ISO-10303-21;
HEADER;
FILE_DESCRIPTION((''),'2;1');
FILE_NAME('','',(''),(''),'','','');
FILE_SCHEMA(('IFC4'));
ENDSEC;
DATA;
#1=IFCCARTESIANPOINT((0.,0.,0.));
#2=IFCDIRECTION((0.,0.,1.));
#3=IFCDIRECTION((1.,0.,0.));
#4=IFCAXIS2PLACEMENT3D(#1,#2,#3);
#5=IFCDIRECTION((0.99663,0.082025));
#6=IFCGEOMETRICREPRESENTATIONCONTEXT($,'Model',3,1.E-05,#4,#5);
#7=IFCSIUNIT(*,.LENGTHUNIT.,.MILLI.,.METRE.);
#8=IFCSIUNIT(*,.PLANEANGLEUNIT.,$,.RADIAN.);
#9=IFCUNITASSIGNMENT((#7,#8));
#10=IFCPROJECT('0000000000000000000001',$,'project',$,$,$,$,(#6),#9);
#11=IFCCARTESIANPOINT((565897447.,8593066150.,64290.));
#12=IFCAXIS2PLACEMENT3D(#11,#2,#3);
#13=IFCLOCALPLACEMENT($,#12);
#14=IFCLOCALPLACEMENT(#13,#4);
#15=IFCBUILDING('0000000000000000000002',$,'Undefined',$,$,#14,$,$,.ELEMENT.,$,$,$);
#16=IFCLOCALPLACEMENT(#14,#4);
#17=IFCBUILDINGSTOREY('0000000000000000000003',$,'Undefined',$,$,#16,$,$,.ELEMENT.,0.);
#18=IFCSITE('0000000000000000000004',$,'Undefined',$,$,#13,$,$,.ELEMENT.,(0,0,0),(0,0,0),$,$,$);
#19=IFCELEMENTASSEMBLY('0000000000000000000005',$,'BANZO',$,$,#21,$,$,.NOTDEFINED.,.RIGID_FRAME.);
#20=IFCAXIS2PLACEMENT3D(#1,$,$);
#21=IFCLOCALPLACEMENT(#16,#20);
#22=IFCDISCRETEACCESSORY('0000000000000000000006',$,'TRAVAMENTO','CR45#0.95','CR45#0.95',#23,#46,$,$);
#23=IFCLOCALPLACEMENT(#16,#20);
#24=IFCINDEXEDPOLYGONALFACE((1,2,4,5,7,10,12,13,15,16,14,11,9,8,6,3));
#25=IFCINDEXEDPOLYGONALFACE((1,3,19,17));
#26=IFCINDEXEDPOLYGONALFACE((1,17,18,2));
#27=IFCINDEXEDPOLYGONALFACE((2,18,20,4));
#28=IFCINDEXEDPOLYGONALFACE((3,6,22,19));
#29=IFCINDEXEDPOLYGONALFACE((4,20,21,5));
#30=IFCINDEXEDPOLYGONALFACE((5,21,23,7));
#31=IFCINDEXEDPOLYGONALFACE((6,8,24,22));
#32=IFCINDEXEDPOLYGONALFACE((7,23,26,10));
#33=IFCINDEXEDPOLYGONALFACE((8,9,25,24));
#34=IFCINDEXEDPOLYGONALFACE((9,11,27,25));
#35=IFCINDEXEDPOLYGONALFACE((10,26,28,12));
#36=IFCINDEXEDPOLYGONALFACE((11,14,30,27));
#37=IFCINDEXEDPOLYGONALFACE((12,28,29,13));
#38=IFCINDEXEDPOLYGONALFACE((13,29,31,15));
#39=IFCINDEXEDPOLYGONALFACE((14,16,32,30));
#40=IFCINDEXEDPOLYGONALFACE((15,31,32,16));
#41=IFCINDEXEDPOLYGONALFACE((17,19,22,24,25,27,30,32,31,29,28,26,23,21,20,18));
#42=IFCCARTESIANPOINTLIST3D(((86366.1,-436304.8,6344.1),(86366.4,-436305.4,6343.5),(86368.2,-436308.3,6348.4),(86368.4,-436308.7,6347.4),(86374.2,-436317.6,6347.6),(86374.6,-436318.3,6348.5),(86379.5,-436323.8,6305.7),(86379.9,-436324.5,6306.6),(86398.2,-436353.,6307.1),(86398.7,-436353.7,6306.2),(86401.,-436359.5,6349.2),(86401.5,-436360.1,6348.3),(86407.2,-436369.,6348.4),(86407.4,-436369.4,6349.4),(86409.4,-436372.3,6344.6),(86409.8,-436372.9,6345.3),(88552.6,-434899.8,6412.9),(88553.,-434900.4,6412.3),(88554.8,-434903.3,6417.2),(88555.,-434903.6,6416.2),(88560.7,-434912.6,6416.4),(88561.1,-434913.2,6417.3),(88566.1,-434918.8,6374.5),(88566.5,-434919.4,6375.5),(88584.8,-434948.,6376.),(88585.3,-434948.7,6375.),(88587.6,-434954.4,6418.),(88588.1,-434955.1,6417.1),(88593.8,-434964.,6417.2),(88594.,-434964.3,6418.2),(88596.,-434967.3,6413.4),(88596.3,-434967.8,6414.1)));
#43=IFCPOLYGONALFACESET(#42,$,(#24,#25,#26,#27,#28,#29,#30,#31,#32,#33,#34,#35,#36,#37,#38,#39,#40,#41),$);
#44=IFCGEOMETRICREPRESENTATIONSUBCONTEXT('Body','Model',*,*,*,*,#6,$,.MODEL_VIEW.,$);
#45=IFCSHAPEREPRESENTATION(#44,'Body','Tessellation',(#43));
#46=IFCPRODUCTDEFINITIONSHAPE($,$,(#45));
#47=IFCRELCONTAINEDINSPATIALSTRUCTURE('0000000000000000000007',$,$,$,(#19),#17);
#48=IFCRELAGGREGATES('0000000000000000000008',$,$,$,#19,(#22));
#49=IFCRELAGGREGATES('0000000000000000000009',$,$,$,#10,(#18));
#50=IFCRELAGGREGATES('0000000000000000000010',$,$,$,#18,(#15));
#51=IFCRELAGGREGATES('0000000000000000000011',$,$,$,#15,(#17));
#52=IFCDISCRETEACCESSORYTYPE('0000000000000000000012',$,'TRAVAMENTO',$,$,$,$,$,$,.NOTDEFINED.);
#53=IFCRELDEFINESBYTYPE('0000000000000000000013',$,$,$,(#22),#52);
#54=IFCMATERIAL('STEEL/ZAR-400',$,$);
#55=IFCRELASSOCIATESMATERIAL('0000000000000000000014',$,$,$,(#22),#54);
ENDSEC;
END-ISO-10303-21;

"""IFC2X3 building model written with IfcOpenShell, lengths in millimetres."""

from ifc_helpers import new_model, si_unit, direction, frame, origin_with_axes, place, context, subcontext, project, spatial, polyline, outline, extrude, material, type_object, element, aggregate, save


model = new_model("IFC2X3")

# Units and contexts
model_context = context("Model", 3, precision=1e-05, world=origin_with_axes(), true_north=direction((0.99663, 0.082025)))
body_context = subcontext(model_context, "Body", "Model", "MODEL_VIEW")
ifc_project = project(units=[si_unit("LENGTHUNIT", "METRE", prefix="MILLI"), si_unit("PLANEANGLEUNIT", "RADIAN")], contexts=[model_context])

# Site, building, storey
site_placement = place(None, frame((565897447.0, 8593066150.0, 64290.0), z_axis=(0.0, 0.0, 1.0), x_axis=(1.0, 0.0, 0.0)))
site = spatial("IfcSite", under=ifc_project, at=site_placement, Name="Undefined", CompositionType="ELEMENT", RefLatitude=(0, 0, 0), RefLongitude=(0, 0, 0))
building_placement = place(site_placement, origin_with_axes())
building = spatial("IfcBuilding", under=site, at=building_placement, Name="Undefined", CompositionType="ELEMENT")
storey_placement = place(building_placement, origin_with_axes())
storey = spatial("IfcBuildingStorey", under=building, at=storey_placement, Name="Undefined", CompositionType="ELEMENT", Elevation=0.0)

# Element assembly
ifc_material_1 = material(Name="STEEL/ZAR-400")
assembly_1_placement = place(storey_placement, origin_with_axes())
assembly_1 = element("IfcElementAssembly", 1, at=assembly_1_placement, inside=storey, Name="BANZO", AssemblyPlace="NOTDEFINED", PredefinedType="RIGID_FRAME")

# Shared definitions
discrete_accessory_type_1 = type_object("IfcDiscreteAccessoryType", Name="TRAVAMENTO")

# Discrete accessory
discrete_accessory_1_placement = place(assembly_1_placement, frame((88574.8, -434933.5, 6396.2), z_axis=(0.029884, 0.002459, -0.99955), x_axis=(-0.840995, -0.540395, -0.026473)))
discrete_accessory_1 = element("IfcDiscreteAccessory", 2, at=discrete_accessory_1_placement, type_object=discrete_accessory_type_1, material=ifc_material_1, Name="TRAVAMENTO", Description="CR45#0.95", ObjectType="CR45#0.95", context=body_context, shape_type="SweptSolid", body=[
    extrude(outline(polyline([(-35.5, -20.5), (-24.9, -20.5), (-17.4, 21.5), (18.1, 21.5), (25.6, -20.5), (36.2, -20.5), (40.1, -16.6), (40.8, -17.3), (36.6, -21.5), (24.8, -21.5), (17.3, 20.5), (-16.6, 20.5), (-24.1, -21.5), (-35.9, -21.5), (-40.1, -17.3), (-39.4, -16.6), (-35.5, -20.5)])), frame((2600.0, 0.0, 0.0), z_axis=(-1.0, 0.0, 0.0), x_axis=(0.0, -1.0, 0.0)), (0.0, 0.0, 1.0), 2600.0),
])
aggregate(assembly_1, [discrete_accessory_1])

save(model, "model.ifc")
